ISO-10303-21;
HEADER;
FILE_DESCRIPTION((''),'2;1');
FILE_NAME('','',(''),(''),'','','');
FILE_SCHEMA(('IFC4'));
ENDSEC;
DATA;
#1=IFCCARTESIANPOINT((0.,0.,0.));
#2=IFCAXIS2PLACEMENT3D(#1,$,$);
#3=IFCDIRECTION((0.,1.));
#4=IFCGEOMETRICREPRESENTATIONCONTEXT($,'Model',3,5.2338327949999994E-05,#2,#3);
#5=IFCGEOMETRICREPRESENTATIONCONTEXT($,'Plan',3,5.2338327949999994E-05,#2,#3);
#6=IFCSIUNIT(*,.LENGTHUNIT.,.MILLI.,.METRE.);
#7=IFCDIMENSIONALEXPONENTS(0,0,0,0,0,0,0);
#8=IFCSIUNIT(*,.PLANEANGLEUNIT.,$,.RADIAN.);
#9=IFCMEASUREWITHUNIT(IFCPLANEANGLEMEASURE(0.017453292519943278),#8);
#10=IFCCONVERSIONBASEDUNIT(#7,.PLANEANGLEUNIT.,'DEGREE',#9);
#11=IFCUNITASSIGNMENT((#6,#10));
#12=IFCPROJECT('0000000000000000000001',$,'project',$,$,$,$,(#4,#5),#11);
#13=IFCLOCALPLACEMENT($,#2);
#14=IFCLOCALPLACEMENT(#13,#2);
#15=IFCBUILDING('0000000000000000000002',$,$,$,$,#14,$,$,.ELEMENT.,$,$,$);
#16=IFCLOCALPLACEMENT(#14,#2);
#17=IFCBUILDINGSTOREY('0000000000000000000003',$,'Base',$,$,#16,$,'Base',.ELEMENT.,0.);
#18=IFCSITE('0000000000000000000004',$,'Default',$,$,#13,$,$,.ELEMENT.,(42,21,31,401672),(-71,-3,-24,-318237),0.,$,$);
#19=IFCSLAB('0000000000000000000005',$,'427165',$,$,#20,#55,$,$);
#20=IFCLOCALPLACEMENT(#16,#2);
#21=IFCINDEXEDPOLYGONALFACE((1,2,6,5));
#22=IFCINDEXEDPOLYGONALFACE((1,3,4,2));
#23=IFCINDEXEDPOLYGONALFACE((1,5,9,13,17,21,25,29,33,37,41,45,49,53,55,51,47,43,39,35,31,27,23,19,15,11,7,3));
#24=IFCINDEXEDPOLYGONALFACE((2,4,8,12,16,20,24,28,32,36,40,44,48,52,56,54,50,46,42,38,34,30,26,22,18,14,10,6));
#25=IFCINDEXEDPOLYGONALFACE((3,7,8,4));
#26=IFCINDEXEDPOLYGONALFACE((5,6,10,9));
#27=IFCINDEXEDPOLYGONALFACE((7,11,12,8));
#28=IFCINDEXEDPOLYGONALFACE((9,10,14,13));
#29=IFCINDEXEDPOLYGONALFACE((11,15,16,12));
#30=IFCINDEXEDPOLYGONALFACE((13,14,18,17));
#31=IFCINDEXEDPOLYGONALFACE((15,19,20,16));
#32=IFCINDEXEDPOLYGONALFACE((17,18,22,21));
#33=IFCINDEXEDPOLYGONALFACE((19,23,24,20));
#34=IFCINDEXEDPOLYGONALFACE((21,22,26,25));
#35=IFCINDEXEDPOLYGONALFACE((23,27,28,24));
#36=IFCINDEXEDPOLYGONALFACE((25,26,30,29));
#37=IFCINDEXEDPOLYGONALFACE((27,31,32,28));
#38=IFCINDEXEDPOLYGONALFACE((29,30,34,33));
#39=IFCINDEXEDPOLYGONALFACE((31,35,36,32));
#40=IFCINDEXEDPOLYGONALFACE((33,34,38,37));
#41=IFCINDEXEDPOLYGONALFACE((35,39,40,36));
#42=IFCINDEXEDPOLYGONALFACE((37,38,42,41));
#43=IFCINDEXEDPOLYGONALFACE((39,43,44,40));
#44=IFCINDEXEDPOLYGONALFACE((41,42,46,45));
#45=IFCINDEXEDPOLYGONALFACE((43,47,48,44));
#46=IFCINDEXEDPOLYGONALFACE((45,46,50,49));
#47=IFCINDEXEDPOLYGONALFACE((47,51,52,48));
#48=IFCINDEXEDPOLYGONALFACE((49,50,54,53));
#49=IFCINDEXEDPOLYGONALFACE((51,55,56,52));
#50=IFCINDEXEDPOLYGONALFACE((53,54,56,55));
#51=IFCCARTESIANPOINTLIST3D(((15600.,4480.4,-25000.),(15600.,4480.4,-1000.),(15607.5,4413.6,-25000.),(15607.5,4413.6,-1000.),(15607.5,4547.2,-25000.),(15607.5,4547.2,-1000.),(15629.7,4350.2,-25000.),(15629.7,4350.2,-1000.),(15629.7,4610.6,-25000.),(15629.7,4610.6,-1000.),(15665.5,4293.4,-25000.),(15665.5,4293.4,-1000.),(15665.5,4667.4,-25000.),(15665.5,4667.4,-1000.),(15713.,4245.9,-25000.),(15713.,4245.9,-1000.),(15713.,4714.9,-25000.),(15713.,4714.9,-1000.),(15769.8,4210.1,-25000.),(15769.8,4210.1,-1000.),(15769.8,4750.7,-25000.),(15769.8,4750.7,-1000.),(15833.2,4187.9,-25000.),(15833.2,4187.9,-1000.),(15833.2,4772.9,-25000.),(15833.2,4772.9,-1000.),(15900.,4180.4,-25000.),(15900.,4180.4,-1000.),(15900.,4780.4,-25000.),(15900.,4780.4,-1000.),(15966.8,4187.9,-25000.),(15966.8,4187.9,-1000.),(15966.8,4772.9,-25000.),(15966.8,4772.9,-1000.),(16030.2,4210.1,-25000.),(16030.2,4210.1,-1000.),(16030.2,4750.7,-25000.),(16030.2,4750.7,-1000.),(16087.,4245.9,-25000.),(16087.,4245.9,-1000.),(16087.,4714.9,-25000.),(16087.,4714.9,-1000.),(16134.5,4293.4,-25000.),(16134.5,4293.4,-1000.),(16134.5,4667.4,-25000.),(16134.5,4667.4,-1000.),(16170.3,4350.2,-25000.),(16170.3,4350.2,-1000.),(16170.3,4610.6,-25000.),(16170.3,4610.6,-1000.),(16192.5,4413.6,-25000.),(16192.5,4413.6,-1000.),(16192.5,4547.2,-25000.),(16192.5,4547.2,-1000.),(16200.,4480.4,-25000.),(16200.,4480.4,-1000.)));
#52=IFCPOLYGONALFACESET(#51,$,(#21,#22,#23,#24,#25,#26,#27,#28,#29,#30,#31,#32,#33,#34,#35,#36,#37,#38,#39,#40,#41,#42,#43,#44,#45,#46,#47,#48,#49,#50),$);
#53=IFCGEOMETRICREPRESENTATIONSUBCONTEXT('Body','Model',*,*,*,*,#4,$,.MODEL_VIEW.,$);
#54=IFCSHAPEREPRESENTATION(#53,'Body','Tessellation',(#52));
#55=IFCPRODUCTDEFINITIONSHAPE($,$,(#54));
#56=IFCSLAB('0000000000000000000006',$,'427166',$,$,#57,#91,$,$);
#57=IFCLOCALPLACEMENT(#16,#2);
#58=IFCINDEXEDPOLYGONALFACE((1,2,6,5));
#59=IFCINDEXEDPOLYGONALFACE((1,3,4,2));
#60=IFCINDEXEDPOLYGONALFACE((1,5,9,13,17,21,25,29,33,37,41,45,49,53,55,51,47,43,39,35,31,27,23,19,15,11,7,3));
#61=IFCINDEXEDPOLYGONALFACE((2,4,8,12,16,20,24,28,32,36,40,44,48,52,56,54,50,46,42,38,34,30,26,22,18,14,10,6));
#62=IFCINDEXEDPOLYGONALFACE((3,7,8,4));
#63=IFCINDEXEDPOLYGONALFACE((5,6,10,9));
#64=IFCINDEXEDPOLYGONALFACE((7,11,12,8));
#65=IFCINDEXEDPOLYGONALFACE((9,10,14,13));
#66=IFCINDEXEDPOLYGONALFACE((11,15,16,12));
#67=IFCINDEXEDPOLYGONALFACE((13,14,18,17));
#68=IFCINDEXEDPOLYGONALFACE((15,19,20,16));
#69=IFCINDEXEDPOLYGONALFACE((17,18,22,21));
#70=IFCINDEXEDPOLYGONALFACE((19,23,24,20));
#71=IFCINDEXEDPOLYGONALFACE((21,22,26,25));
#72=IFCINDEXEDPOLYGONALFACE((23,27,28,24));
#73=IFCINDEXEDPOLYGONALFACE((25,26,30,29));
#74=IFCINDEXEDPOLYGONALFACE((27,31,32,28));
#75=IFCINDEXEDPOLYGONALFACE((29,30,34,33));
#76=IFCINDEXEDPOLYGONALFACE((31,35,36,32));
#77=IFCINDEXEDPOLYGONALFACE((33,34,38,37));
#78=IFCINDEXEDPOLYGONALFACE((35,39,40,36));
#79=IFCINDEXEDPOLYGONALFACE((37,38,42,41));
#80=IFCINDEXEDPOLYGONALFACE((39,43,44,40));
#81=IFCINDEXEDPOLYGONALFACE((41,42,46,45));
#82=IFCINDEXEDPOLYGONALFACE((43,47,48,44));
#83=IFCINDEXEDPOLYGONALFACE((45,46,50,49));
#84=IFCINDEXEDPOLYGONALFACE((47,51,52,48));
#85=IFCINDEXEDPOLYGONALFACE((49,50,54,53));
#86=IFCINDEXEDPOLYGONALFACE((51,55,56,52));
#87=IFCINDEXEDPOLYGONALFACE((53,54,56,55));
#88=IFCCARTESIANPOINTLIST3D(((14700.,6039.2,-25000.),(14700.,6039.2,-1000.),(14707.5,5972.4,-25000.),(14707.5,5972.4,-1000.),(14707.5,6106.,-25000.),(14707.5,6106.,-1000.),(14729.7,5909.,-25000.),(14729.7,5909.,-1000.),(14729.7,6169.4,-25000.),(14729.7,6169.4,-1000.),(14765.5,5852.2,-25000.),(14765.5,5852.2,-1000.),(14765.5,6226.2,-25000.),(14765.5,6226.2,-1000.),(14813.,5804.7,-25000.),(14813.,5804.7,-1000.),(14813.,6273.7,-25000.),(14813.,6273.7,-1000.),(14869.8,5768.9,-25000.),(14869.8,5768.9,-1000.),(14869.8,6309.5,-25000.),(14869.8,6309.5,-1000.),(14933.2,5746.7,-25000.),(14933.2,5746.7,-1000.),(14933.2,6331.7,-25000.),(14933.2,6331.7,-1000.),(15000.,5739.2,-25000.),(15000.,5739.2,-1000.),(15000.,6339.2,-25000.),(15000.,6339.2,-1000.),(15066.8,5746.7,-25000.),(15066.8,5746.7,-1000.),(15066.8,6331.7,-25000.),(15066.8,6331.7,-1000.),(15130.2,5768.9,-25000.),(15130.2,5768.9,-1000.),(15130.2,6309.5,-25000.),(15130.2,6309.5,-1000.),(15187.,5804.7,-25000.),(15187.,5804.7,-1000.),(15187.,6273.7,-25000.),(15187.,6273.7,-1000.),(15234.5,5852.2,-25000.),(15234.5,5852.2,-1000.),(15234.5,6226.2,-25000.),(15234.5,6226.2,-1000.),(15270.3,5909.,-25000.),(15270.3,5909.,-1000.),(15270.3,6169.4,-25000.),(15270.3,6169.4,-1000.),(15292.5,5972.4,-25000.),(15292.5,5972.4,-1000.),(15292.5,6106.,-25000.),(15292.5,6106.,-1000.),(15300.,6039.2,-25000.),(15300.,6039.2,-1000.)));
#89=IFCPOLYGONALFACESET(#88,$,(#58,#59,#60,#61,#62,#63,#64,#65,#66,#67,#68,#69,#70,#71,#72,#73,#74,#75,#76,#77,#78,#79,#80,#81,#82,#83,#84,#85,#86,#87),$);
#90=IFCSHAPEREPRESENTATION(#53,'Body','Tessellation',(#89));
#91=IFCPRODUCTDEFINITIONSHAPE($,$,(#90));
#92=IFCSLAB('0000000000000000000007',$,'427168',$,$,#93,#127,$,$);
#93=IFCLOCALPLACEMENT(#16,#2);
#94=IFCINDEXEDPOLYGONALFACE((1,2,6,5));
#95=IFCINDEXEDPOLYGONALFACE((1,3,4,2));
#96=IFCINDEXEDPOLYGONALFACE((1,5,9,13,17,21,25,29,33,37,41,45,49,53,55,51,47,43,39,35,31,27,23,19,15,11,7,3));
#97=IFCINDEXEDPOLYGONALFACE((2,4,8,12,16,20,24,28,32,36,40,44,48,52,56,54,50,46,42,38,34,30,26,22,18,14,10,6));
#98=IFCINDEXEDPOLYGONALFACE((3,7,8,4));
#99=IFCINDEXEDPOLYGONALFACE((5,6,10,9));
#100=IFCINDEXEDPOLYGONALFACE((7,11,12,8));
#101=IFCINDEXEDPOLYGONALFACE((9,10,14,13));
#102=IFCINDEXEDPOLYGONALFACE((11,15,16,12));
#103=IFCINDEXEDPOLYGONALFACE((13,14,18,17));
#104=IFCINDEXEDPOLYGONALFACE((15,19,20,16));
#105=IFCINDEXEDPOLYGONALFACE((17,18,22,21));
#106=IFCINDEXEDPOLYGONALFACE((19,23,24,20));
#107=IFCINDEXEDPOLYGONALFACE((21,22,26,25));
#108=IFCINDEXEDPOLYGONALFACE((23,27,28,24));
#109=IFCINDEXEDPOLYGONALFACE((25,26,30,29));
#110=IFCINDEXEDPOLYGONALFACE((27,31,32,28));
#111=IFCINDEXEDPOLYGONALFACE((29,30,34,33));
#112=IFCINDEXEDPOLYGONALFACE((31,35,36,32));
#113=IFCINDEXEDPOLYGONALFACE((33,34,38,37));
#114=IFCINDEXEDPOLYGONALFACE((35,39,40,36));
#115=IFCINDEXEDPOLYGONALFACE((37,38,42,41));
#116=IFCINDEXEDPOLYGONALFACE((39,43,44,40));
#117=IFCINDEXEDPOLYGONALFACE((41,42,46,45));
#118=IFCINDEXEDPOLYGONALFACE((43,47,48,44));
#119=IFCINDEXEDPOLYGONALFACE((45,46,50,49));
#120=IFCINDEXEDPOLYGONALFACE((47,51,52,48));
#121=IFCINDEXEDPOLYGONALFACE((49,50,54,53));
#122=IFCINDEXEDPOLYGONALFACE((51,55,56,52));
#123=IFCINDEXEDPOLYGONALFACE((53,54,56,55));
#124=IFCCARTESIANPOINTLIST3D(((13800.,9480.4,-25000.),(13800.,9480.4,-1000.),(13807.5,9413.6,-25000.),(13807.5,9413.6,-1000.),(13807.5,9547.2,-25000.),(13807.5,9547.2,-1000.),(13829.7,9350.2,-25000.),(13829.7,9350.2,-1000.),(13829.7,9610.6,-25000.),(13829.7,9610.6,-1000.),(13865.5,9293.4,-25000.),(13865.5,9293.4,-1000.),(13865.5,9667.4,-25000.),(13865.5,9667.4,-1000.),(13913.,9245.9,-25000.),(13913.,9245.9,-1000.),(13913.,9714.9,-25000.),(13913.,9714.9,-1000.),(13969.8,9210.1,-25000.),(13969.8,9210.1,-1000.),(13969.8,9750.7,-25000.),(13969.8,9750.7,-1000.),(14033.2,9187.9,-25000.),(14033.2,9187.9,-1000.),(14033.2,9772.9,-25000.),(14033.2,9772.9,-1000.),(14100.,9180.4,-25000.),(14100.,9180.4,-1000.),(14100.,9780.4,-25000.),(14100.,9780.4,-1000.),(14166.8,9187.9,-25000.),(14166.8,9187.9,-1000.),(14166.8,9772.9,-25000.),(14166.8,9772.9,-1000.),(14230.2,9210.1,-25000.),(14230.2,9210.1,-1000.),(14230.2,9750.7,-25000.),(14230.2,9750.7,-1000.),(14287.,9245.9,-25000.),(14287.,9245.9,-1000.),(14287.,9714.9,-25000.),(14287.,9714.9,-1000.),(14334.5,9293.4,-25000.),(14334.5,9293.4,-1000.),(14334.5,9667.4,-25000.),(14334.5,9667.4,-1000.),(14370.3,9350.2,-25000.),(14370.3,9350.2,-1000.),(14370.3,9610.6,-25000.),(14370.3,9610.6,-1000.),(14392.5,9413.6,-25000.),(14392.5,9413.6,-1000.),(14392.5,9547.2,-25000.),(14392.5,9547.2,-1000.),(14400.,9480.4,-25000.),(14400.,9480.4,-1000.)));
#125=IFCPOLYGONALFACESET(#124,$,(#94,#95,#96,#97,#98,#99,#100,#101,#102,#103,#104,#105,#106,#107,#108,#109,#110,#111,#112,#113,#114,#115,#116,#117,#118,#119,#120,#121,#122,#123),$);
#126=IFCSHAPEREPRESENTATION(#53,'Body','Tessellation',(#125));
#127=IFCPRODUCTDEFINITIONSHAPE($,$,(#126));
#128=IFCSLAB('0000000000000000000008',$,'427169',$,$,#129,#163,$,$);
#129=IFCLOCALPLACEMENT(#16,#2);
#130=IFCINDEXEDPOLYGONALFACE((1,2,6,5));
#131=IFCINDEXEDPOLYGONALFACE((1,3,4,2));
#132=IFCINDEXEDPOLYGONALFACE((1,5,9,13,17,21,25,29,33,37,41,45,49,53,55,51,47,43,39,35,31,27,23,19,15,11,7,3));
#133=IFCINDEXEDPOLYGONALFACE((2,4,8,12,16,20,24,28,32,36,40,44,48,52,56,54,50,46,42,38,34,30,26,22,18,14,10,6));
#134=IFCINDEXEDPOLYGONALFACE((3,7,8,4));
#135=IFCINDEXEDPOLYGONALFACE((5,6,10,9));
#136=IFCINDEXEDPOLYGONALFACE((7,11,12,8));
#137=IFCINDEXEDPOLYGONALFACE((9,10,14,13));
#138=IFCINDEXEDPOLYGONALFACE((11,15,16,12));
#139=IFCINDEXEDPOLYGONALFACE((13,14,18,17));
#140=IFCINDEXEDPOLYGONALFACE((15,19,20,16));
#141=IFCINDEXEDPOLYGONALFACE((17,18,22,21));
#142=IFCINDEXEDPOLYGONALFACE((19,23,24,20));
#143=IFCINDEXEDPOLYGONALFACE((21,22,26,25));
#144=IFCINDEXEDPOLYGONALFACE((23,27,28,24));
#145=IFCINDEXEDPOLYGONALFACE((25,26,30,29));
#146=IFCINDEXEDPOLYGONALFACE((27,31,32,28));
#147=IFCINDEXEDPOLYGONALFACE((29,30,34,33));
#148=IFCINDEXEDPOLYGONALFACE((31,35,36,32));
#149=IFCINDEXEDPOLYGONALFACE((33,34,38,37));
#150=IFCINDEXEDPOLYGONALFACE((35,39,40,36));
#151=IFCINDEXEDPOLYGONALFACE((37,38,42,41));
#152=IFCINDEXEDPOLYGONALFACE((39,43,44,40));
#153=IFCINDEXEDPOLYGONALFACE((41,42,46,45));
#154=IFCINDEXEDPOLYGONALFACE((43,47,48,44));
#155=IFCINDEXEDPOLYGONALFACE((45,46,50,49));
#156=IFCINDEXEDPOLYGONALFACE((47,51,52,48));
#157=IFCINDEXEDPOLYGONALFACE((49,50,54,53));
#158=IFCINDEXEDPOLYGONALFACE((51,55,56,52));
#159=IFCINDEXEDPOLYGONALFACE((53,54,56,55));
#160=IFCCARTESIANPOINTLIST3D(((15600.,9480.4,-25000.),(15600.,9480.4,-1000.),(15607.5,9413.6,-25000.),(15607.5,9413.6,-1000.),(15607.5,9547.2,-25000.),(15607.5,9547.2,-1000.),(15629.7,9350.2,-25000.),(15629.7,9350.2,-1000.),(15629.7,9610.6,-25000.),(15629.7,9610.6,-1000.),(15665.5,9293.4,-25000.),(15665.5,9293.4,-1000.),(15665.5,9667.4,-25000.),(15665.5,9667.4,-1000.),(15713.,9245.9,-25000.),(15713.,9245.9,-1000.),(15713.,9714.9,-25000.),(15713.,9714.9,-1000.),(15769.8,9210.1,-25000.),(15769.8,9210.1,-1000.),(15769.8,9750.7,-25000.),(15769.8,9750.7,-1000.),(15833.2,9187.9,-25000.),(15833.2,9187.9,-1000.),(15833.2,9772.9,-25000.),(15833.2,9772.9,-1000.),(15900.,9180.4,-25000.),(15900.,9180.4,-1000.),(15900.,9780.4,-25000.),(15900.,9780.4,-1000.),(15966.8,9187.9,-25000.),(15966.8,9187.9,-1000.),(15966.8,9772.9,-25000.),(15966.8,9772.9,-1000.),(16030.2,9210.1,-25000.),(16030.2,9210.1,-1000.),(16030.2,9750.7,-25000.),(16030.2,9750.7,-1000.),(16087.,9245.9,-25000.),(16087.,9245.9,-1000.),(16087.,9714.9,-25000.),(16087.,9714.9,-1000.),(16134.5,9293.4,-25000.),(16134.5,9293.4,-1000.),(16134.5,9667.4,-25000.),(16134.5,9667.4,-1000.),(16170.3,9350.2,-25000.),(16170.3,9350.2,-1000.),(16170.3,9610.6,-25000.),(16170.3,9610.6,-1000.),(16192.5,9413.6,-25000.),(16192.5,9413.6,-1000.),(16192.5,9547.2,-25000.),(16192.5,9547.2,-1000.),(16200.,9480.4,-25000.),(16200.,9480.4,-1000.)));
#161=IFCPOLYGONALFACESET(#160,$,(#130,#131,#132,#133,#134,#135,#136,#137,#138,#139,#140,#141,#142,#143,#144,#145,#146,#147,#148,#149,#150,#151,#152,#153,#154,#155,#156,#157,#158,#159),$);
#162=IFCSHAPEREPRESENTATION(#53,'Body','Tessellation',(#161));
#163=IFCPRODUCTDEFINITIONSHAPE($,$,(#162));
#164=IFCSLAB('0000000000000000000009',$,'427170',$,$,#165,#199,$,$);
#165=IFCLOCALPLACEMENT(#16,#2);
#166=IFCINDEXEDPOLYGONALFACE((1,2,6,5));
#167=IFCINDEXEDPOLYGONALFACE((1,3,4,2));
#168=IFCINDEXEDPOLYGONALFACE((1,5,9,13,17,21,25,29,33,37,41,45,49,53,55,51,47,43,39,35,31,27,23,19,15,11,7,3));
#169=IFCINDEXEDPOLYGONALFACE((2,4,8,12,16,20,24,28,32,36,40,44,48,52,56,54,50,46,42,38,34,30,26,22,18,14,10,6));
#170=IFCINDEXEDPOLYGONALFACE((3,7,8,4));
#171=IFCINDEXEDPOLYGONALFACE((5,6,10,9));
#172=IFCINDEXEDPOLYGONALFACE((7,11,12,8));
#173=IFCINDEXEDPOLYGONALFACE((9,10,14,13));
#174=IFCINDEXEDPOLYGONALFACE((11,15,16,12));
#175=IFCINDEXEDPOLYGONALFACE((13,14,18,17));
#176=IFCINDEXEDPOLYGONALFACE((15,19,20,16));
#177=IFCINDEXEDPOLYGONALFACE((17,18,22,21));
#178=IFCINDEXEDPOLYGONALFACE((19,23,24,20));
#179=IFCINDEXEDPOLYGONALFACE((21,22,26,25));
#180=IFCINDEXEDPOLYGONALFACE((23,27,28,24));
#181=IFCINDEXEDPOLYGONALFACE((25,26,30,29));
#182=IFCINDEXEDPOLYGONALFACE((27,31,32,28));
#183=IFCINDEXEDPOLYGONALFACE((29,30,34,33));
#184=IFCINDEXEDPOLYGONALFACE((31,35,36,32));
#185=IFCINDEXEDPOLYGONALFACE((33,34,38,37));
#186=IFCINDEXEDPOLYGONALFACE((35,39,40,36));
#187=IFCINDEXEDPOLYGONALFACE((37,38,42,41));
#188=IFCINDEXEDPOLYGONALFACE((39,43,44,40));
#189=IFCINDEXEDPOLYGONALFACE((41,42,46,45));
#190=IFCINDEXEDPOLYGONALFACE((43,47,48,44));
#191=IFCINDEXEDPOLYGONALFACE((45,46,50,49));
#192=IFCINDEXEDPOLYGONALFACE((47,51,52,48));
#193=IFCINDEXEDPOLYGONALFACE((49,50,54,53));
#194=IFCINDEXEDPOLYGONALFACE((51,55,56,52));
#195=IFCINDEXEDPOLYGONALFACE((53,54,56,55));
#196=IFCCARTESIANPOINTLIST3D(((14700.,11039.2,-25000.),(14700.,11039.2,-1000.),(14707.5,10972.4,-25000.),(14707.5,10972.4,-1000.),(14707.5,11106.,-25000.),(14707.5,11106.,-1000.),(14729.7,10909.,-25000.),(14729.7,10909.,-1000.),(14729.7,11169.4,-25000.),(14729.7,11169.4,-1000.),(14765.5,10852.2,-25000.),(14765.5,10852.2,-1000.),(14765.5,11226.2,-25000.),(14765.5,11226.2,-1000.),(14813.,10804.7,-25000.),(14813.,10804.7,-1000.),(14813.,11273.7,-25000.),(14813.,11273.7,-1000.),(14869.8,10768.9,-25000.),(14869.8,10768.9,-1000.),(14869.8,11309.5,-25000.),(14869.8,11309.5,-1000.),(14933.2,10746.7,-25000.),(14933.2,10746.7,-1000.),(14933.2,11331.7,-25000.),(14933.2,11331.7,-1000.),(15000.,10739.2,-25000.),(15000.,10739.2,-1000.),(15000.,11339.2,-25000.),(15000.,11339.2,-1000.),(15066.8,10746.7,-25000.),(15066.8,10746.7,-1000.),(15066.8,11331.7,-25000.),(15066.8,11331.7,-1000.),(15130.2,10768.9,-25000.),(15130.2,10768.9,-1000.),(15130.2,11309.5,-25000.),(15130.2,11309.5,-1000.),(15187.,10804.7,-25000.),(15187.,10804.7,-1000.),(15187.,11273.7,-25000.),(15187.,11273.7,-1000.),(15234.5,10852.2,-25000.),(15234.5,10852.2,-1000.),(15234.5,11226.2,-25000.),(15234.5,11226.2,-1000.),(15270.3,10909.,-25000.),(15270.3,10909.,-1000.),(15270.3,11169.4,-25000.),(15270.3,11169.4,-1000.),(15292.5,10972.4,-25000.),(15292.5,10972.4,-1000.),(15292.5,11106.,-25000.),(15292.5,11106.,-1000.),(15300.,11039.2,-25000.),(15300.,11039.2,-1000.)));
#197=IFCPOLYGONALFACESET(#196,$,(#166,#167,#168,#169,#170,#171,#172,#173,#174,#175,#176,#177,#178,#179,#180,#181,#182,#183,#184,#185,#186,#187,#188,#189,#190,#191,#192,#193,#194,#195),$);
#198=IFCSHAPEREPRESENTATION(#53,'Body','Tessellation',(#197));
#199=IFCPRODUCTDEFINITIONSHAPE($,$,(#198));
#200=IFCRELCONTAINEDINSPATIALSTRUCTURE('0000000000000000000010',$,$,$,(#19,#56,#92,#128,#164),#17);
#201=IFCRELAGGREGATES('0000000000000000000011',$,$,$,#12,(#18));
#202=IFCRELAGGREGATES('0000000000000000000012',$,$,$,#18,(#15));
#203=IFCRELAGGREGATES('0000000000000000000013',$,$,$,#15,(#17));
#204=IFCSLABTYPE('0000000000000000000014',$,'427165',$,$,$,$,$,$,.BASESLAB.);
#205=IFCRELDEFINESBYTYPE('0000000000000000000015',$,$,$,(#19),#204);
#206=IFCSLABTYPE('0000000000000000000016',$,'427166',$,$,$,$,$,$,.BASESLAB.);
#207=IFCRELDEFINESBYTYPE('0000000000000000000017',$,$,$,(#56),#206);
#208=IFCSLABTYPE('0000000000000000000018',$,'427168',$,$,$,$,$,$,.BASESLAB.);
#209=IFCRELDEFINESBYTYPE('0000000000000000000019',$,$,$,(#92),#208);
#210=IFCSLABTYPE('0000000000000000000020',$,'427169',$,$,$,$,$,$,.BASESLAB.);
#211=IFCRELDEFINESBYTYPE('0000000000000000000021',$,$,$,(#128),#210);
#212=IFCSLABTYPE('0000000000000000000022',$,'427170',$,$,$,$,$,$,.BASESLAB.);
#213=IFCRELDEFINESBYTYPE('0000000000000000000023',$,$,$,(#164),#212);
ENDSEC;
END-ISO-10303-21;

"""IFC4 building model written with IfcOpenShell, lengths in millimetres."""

from ifc_helpers import new_model, entity, si_unit, converted_unit, direction, frame, origin, place, context, subcontext, project, spatial, arc, indexed_curve, outline, extrude, type_object, element, save


model = new_model("IFC4")

# Units and contexts
model_context = context("Model", 3, precision=5.2338327949999994e-05, world=origin(), true_north=direction((0.0, 1.0)))
plan_context = context("Plan", 3, precision=5.2338327949999994e-05, world=origin(), true_north=direction((0.0, 1.0)))
body_context = subcontext(model_context, "Body", "Model", "MODEL_VIEW")
ifc_project = project(units=[si_unit("LENGTHUNIT", "METRE", prefix="MILLI"), converted_unit("PLANEANGLEUNIT", "DEGREE", entity("IfcPlaneAngleMeasure", 0.017453292519943278), si_unit("PLANEANGLEUNIT", "RADIAN"), dimensions=[0, 0, 0, 0, 0, 0, 0])], contexts=[model_context, plan_context])

# Site, building, storey
site_placement = place(None, origin())
site = spatial("IfcSite", under=ifc_project, at=site_placement, Name="Default", CompositionType="ELEMENT", RefLatitude=(42, 21, 31, 401672), RefLongitude=(-71, -3, -24, -318237), RefElevation=0.0)
building_placement = place(site_placement, origin())
building = spatial("IfcBuilding", under=site, at=building_placement, CompositionType="ELEMENT")
storey_placement = place(building_placement, origin())
storey = spatial("IfcBuildingStorey", under=building, at=storey_placement, Name="Base", LongName="Base", CompositionType="ELEMENT", Elevation=0.0)

# Slabs
slab_type_1 = type_object("IfcSlabType", Name="427165", PredefinedType="BASESLAB")
slab_1_placement = place(storey_placement, origin())
element("IfcSlab", 1, at=slab_1_placement, inside=storey, type_object=slab_type_1, Name="427165", context=body_context, shape_type="SweptSolid", body=[
    extrude(outline(indexed_curve([(300.0, 0.0), (0.0, 300.0), (-300.0, 0.0), (0.0, -300.0)], segments=[arc(1, 2, 3), arc(3, 4, 1)], self_intersect=False)), frame((15900.0, 4480.4, -25000.0)), (0.0, 0.0, 1.0), 24000.0),
])
slab_type_2 = type_object("IfcSlabType", Name="427166", PredefinedType="BASESLAB")
slab_2_placement = place(storey_placement, origin())
element("IfcSlab", 2, at=slab_2_placement, inside=storey, type_object=slab_type_2, Name="427166", context=body_context, shape_type="SweptSolid", body=[
    extrude(outline(indexed_curve([(300.0, 0.0), (0.0, 300.0), (-300.0, 0.0), (0.0, -300.0)], segments=[arc(1, 2, 3), arc(3, 4, 1)], self_intersect=False)), frame((15000.0, 6039.2, -25000.0)), (0.0, 0.0, 1.0), 24000.0),
])
slab_type_3 = type_object("IfcSlabType", Name="427168", PredefinedType="BASESLAB")
slab_3_placement = place(storey_placement, origin())
element("IfcSlab", 3, at=slab_3_placement, inside=storey, type_object=slab_type_3, Name="427168", context=body_context, shape_type="SweptSolid", body=[
    extrude(outline(indexed_curve([(300.0, 0.0), (0.0, 300.0), (-300.0, 0.0), (0.0, -300.0)], segments=[arc(1, 2, 3), arc(3, 4, 1)], self_intersect=False)), frame((14100.0, 9480.4, -25000.0)), (0.0, 0.0, 1.0), 24000.0),
])
slab_type_4 = type_object("IfcSlabType", Name="427169", PredefinedType="BASESLAB")
slab_4_placement = place(storey_placement, origin())
element("IfcSlab", 4, at=slab_4_placement, inside=storey, type_object=slab_type_4, Name="427169", context=body_context, shape_type="SweptSolid", body=[
    extrude(outline(indexed_curve([(300.0, 0.0), (0.0, 300.0), (-300.0, 0.0), (0.0, -300.0)], segments=[arc(1, 2, 3), arc(3, 4, 1)], self_intersect=False)), frame((15900.0, 9480.4, -25000.0)), (0.0, 0.0, 1.0), 24000.0),
])
slab_type_5 = type_object("IfcSlabType", Name="427170", PredefinedType="BASESLAB")
slab_5_placement = place(storey_placement, origin())
element("IfcSlab", 5, at=slab_5_placement, inside=storey, type_object=slab_type_5, Name="427170", context=body_context, shape_type="SweptSolid", body=[
    extrude(outline(indexed_curve([(300.0, 0.0), (0.0, 300.0), (-300.0, 0.0), (0.0, -300.0)], segments=[arc(1, 2, 3), arc(3, 4, 1)], self_intersect=False)), frame((15000.0, 11039.2, -25000.0)), (0.0, 0.0, 1.0), 24000.0),
])

save(model, "model.ifc")
